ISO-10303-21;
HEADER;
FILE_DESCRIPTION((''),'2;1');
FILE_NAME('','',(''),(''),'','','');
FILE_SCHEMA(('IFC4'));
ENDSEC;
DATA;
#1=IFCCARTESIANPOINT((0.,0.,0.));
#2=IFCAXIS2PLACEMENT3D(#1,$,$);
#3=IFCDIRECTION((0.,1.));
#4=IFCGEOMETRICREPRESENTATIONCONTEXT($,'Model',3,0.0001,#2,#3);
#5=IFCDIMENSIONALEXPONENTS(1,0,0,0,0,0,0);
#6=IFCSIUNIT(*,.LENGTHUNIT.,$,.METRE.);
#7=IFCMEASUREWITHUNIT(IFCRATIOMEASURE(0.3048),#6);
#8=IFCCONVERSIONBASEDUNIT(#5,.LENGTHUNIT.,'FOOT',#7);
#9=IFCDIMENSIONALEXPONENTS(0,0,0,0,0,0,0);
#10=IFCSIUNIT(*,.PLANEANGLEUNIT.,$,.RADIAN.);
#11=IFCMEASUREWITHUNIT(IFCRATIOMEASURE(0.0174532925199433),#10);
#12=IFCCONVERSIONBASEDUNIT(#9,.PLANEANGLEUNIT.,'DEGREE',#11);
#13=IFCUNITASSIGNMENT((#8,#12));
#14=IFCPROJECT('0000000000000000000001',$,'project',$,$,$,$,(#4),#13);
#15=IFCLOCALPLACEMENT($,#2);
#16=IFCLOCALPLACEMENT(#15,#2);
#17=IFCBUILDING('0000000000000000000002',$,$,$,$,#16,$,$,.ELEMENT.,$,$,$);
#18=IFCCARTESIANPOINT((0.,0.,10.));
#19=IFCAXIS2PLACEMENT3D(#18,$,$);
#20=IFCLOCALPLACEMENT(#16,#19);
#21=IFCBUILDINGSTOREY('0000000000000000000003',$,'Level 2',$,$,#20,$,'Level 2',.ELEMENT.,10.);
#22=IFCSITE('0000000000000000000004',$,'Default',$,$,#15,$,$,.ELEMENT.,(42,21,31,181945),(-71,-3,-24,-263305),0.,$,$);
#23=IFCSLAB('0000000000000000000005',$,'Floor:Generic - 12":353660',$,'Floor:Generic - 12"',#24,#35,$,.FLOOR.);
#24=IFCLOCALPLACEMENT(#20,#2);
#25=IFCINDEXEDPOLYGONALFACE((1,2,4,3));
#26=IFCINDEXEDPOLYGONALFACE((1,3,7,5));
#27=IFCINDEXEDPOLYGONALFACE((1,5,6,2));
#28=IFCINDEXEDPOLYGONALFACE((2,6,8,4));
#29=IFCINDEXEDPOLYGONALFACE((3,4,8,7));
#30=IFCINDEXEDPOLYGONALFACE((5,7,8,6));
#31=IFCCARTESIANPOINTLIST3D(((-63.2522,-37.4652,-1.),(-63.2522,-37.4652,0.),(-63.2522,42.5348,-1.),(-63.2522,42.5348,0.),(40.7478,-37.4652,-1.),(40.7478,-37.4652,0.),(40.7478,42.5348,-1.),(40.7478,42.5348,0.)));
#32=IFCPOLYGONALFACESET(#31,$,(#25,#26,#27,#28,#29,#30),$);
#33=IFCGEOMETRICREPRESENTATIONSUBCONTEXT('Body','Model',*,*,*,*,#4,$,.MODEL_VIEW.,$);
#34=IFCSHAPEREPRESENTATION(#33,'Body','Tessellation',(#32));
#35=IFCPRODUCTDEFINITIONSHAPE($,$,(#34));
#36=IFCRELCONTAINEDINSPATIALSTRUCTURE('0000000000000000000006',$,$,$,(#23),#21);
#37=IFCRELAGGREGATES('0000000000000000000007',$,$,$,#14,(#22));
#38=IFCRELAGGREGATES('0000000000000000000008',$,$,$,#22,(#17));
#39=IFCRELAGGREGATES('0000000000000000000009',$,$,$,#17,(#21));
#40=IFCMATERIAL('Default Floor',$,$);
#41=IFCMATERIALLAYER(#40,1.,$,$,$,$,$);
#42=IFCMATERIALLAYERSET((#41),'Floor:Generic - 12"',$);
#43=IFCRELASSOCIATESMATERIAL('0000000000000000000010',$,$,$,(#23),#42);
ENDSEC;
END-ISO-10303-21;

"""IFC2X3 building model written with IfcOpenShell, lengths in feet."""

from ifc_helpers import new_model, entity, si_unit, converted_unit, direction, frame, origin, origin_2d_with_axis, place, context, subcontext, project, spatial, rectangle, extrude, material, layer, layer_set, layer_usage, element, save


model = new_model("IFC2X3")

# Units and contexts
model_context = context("Model", 3, precision=0.0001, world=origin(), true_north=direction((0.0, 1.0)))
body_context = subcontext(model_context, "Body", "Model", "MODEL_VIEW")
ifc_project = project(units=[converted_unit("LENGTHUNIT", "FOOT", entity("IfcRatioMeasure", 0.3048), si_unit("LENGTHUNIT", "METRE"), dimensions=[1, 0, 0, 0, 0, 0, 0]), converted_unit("PLANEANGLEUNIT", "DEGREE", entity("IfcRatioMeasure", 0.0174532925199433), si_unit("PLANEANGLEUNIT", "RADIAN"), dimensions=[0, 0, 0, 0, 0, 0, 0])], contexts=[model_context])

# Site, building, storey
site_placement = place(None, origin())
site = spatial("IfcSite", under=ifc_project, at=site_placement, Name="Default", CompositionType="ELEMENT", RefLatitude=(42, 21, 31, 181945), RefLongitude=(-71, -3, -24, -263305), RefElevation=0.0)
building_placement = place(site_placement, origin())
building = spatial("IfcBuilding", under=site, at=building_placement, CompositionType="ELEMENT")
storey_placement = place(building_placement, frame((0.0, 0.0, 10.0)))
storey = spatial("IfcBuildingStorey", under=building, at=storey_placement, Name="Level 2", LongName="Level 2", CompositionType="ELEMENT", Elevation=10.0)

# Slab
ifc_material = material(Name="Default Floor")
ifc_layer = layer(ifc_material, 1.0)
ifc_layer_set = layer_set([ifc_layer], Name="Floor:Generic - 12\"")
ifc_layer_usage = layer_usage(ifc_layer_set, "AXIS3", "POSITIVE", 0.0)
slab_placement = place(storey_placement, origin())
element("IfcSlab", 1, at=slab_placement, inside=storey, material=ifc_layer_usage, Name="Floor:Generic - 12\":353660", ObjectType="Floor:Generic - 12\"", PredefinedType="FLOOR", context=body_context, shape_type="SweptSolid", body=[
    extrude(rectangle(XDim=80.0, YDim=104.0, at=origin_2d_with_axis()), frame((-11.2522, 2.5348, 0.0), z_axis=(0.0, 0.0, -1.0), x_axis=(0.0, 1.0, 0.0)), (0.0, 0.0, 1.0), 1.0),
])

save(model, "model.ifc")
